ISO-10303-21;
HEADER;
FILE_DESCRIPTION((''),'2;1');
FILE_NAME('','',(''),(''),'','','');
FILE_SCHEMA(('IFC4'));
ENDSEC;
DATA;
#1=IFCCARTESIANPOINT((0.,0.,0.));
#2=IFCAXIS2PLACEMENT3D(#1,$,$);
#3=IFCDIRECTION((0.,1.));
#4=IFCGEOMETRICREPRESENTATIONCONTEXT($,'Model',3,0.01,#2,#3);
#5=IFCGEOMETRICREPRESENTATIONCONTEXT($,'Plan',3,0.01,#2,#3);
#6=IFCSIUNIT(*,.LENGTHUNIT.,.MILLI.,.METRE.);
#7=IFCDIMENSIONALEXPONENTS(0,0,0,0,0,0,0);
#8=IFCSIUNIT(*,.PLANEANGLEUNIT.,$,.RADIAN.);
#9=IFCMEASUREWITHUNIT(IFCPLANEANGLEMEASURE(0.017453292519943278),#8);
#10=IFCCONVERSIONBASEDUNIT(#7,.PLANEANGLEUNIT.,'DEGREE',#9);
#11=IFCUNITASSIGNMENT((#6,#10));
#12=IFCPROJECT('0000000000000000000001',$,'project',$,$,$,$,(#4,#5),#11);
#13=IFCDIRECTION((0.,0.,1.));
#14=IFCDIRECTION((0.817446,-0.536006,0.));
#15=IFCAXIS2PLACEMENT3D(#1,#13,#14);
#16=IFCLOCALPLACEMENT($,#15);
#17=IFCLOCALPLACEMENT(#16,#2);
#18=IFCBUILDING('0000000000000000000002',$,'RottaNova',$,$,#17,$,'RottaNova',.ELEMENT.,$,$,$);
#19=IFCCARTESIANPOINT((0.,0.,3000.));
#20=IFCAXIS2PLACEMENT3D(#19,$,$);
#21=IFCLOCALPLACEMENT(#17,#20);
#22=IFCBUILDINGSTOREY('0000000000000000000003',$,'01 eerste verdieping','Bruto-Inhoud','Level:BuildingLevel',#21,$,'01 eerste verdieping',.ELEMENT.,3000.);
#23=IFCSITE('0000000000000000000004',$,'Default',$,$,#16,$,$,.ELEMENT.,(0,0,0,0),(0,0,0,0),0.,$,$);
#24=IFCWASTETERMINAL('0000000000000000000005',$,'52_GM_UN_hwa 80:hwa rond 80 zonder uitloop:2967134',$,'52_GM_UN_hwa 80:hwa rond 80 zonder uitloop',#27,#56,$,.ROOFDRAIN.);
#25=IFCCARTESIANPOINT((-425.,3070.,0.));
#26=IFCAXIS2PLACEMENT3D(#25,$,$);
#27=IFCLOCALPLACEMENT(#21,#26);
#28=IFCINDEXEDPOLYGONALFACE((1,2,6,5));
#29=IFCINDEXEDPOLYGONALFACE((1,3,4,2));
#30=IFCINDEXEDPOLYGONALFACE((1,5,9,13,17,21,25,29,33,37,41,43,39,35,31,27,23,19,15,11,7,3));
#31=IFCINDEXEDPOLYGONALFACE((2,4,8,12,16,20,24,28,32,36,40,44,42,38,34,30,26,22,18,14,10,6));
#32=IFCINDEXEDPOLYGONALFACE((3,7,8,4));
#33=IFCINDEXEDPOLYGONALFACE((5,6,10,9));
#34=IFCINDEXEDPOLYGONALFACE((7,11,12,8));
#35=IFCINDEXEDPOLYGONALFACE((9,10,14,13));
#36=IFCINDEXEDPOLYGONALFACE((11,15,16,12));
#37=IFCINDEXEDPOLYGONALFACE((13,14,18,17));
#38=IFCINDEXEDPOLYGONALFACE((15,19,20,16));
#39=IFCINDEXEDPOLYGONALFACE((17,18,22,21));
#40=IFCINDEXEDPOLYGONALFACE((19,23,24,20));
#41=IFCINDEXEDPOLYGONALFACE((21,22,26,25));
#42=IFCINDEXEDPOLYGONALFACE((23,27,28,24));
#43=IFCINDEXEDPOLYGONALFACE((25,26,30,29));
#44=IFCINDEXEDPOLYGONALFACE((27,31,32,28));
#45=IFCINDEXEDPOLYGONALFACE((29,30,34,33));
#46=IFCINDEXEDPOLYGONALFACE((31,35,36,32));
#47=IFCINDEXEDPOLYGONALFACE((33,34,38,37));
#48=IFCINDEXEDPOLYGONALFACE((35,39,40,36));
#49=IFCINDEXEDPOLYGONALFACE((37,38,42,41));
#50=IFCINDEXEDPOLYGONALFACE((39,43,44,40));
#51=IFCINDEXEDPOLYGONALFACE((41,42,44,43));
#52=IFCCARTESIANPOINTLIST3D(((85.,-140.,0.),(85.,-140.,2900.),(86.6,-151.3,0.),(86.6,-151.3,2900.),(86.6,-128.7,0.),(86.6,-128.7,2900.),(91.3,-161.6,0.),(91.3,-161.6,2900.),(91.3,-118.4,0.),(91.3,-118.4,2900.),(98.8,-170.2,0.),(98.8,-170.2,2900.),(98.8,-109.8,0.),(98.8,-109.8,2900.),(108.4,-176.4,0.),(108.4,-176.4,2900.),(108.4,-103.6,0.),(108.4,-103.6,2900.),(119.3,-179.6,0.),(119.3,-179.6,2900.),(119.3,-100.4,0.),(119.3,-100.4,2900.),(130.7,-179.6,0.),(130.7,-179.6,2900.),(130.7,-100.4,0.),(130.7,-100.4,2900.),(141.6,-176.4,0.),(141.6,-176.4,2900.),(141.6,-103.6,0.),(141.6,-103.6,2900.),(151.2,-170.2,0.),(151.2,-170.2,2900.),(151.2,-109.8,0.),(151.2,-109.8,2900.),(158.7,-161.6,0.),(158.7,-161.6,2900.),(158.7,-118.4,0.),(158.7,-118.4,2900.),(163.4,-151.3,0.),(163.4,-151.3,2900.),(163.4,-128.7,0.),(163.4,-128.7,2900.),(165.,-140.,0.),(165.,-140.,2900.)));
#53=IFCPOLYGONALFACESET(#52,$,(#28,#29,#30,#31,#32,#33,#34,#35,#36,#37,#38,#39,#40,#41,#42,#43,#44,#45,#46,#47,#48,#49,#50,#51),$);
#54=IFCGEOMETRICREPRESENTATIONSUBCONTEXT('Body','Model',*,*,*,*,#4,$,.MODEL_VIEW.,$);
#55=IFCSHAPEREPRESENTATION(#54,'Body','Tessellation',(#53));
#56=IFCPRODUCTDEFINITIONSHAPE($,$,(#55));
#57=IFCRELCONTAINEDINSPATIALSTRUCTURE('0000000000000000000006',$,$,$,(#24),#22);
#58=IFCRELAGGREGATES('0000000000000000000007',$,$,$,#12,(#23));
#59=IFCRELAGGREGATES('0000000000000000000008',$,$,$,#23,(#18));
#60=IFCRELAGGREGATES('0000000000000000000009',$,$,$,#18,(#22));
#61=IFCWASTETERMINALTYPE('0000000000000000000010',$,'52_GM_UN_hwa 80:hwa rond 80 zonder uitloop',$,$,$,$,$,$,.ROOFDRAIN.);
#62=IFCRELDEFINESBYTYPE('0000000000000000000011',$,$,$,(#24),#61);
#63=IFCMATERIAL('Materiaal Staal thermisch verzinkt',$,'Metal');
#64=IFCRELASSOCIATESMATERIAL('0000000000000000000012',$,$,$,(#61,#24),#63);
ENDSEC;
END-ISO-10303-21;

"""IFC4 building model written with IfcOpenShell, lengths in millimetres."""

from ifc_helpers import new_model, entity, si_unit, converted_unit, direction, frame, origin, place, context, subcontext, project, spatial, arc, indexed_curve, outline, extrude, source, transform, mapped, material, type_object, type_shapes, element, save


model = new_model("IFC4")

# Units and contexts
model_context = context("Model", 3, precision=0.01, world=origin(), true_north=direction((0.0, 1.0)))
plan_context = context("Plan", 3, precision=0.01, world=origin(), true_north=direction((0.0, 1.0)))
body_context = subcontext(model_context, "Body", "Model", "MODEL_VIEW")
ifc_project = project(units=[si_unit("LENGTHUNIT", "METRE", prefix="MILLI"), converted_unit("PLANEANGLEUNIT", "DEGREE", entity("IfcPlaneAngleMeasure", 0.017453292519943278), si_unit("PLANEANGLEUNIT", "RADIAN"), dimensions=[0, 0, 0, 0, 0, 0, 0])], contexts=[model_context, plan_context])

# Site, building, storey
site_placement = place(None, frame((0.0, 0.0, 0.0), z_axis=(0.0, 0.0, 1.0), x_axis=(0.817446, -0.536006, 0.0)))
site = spatial("IfcSite", under=ifc_project, at=site_placement, Name="Default", CompositionType="ELEMENT", RefLatitude=(0, 0, 0, 0), RefLongitude=(0, 0, 0, 0), RefElevation=0.0)
building_placement = place(site_placement, origin())
building = spatial("IfcBuilding", under=site, at=building_placement, Name="RottaNova", LongName="RottaNova", CompositionType="ELEMENT")
storey_placement = place(building_placement, frame((0.0, 0.0, 3000.0)))
storey = spatial("IfcBuildingStorey", under=building, at=storey_placement, Name="01 eerste verdieping", Description="Bruto-Inhoud", ObjectType="Level:BuildingLevel", LongName="01 eerste verdieping", CompositionType="ELEMENT", Elevation=3000.0)

# Waste terminal
ifc_material_1 = material(Name="Materiaal Staal thermisch verzinkt", Category="Metal")
waste_terminal_type = type_object("IfcWasteTerminalType", Name="52_GM_UN_hwa 80:hwa rond 80 zonder uitloop", PredefinedType="ROOFDRAIN", material=ifc_material_1)
shared_shape_1 = source(origin(), body_context, "Body", "SweptSolid", [
    extrude(outline(indexed_curve([(-40.0, 0.0), (0.0, -40.0), (40.0, 0.0), (0.0, 40.0)], segments=[arc(1, 2, 3), arc(3, 4, 1)], self_intersect=False)), frame((125.0, -140.0, 0.0)), (0.0, 0.0, 1.0), 2900.0),
])
type_shapes(waste_terminal_type, [shared_shape_1])
waste_terminal_placement = place(storey_placement, frame((-425.0, 3070.0, 0.0)))
element("IfcWasteTerminal", 1, at=waste_terminal_placement, inside=storey, type_object=waste_terminal_type, material=ifc_material_1, Name="52_GM_UN_hwa 80:hwa rond 80 zonder uitloop:2967134", ObjectType="52_GM_UN_hwa 80:hwa rond 80 zonder uitloop", PredefinedType="ROOFDRAIN", context=body_context, shape_type="MappedRepresentation", body=[
    mapped(shared_shape_1, transform((0.0, 0.0, 0.0), scale=1.0)),
])

save(model, "model.ifc")
